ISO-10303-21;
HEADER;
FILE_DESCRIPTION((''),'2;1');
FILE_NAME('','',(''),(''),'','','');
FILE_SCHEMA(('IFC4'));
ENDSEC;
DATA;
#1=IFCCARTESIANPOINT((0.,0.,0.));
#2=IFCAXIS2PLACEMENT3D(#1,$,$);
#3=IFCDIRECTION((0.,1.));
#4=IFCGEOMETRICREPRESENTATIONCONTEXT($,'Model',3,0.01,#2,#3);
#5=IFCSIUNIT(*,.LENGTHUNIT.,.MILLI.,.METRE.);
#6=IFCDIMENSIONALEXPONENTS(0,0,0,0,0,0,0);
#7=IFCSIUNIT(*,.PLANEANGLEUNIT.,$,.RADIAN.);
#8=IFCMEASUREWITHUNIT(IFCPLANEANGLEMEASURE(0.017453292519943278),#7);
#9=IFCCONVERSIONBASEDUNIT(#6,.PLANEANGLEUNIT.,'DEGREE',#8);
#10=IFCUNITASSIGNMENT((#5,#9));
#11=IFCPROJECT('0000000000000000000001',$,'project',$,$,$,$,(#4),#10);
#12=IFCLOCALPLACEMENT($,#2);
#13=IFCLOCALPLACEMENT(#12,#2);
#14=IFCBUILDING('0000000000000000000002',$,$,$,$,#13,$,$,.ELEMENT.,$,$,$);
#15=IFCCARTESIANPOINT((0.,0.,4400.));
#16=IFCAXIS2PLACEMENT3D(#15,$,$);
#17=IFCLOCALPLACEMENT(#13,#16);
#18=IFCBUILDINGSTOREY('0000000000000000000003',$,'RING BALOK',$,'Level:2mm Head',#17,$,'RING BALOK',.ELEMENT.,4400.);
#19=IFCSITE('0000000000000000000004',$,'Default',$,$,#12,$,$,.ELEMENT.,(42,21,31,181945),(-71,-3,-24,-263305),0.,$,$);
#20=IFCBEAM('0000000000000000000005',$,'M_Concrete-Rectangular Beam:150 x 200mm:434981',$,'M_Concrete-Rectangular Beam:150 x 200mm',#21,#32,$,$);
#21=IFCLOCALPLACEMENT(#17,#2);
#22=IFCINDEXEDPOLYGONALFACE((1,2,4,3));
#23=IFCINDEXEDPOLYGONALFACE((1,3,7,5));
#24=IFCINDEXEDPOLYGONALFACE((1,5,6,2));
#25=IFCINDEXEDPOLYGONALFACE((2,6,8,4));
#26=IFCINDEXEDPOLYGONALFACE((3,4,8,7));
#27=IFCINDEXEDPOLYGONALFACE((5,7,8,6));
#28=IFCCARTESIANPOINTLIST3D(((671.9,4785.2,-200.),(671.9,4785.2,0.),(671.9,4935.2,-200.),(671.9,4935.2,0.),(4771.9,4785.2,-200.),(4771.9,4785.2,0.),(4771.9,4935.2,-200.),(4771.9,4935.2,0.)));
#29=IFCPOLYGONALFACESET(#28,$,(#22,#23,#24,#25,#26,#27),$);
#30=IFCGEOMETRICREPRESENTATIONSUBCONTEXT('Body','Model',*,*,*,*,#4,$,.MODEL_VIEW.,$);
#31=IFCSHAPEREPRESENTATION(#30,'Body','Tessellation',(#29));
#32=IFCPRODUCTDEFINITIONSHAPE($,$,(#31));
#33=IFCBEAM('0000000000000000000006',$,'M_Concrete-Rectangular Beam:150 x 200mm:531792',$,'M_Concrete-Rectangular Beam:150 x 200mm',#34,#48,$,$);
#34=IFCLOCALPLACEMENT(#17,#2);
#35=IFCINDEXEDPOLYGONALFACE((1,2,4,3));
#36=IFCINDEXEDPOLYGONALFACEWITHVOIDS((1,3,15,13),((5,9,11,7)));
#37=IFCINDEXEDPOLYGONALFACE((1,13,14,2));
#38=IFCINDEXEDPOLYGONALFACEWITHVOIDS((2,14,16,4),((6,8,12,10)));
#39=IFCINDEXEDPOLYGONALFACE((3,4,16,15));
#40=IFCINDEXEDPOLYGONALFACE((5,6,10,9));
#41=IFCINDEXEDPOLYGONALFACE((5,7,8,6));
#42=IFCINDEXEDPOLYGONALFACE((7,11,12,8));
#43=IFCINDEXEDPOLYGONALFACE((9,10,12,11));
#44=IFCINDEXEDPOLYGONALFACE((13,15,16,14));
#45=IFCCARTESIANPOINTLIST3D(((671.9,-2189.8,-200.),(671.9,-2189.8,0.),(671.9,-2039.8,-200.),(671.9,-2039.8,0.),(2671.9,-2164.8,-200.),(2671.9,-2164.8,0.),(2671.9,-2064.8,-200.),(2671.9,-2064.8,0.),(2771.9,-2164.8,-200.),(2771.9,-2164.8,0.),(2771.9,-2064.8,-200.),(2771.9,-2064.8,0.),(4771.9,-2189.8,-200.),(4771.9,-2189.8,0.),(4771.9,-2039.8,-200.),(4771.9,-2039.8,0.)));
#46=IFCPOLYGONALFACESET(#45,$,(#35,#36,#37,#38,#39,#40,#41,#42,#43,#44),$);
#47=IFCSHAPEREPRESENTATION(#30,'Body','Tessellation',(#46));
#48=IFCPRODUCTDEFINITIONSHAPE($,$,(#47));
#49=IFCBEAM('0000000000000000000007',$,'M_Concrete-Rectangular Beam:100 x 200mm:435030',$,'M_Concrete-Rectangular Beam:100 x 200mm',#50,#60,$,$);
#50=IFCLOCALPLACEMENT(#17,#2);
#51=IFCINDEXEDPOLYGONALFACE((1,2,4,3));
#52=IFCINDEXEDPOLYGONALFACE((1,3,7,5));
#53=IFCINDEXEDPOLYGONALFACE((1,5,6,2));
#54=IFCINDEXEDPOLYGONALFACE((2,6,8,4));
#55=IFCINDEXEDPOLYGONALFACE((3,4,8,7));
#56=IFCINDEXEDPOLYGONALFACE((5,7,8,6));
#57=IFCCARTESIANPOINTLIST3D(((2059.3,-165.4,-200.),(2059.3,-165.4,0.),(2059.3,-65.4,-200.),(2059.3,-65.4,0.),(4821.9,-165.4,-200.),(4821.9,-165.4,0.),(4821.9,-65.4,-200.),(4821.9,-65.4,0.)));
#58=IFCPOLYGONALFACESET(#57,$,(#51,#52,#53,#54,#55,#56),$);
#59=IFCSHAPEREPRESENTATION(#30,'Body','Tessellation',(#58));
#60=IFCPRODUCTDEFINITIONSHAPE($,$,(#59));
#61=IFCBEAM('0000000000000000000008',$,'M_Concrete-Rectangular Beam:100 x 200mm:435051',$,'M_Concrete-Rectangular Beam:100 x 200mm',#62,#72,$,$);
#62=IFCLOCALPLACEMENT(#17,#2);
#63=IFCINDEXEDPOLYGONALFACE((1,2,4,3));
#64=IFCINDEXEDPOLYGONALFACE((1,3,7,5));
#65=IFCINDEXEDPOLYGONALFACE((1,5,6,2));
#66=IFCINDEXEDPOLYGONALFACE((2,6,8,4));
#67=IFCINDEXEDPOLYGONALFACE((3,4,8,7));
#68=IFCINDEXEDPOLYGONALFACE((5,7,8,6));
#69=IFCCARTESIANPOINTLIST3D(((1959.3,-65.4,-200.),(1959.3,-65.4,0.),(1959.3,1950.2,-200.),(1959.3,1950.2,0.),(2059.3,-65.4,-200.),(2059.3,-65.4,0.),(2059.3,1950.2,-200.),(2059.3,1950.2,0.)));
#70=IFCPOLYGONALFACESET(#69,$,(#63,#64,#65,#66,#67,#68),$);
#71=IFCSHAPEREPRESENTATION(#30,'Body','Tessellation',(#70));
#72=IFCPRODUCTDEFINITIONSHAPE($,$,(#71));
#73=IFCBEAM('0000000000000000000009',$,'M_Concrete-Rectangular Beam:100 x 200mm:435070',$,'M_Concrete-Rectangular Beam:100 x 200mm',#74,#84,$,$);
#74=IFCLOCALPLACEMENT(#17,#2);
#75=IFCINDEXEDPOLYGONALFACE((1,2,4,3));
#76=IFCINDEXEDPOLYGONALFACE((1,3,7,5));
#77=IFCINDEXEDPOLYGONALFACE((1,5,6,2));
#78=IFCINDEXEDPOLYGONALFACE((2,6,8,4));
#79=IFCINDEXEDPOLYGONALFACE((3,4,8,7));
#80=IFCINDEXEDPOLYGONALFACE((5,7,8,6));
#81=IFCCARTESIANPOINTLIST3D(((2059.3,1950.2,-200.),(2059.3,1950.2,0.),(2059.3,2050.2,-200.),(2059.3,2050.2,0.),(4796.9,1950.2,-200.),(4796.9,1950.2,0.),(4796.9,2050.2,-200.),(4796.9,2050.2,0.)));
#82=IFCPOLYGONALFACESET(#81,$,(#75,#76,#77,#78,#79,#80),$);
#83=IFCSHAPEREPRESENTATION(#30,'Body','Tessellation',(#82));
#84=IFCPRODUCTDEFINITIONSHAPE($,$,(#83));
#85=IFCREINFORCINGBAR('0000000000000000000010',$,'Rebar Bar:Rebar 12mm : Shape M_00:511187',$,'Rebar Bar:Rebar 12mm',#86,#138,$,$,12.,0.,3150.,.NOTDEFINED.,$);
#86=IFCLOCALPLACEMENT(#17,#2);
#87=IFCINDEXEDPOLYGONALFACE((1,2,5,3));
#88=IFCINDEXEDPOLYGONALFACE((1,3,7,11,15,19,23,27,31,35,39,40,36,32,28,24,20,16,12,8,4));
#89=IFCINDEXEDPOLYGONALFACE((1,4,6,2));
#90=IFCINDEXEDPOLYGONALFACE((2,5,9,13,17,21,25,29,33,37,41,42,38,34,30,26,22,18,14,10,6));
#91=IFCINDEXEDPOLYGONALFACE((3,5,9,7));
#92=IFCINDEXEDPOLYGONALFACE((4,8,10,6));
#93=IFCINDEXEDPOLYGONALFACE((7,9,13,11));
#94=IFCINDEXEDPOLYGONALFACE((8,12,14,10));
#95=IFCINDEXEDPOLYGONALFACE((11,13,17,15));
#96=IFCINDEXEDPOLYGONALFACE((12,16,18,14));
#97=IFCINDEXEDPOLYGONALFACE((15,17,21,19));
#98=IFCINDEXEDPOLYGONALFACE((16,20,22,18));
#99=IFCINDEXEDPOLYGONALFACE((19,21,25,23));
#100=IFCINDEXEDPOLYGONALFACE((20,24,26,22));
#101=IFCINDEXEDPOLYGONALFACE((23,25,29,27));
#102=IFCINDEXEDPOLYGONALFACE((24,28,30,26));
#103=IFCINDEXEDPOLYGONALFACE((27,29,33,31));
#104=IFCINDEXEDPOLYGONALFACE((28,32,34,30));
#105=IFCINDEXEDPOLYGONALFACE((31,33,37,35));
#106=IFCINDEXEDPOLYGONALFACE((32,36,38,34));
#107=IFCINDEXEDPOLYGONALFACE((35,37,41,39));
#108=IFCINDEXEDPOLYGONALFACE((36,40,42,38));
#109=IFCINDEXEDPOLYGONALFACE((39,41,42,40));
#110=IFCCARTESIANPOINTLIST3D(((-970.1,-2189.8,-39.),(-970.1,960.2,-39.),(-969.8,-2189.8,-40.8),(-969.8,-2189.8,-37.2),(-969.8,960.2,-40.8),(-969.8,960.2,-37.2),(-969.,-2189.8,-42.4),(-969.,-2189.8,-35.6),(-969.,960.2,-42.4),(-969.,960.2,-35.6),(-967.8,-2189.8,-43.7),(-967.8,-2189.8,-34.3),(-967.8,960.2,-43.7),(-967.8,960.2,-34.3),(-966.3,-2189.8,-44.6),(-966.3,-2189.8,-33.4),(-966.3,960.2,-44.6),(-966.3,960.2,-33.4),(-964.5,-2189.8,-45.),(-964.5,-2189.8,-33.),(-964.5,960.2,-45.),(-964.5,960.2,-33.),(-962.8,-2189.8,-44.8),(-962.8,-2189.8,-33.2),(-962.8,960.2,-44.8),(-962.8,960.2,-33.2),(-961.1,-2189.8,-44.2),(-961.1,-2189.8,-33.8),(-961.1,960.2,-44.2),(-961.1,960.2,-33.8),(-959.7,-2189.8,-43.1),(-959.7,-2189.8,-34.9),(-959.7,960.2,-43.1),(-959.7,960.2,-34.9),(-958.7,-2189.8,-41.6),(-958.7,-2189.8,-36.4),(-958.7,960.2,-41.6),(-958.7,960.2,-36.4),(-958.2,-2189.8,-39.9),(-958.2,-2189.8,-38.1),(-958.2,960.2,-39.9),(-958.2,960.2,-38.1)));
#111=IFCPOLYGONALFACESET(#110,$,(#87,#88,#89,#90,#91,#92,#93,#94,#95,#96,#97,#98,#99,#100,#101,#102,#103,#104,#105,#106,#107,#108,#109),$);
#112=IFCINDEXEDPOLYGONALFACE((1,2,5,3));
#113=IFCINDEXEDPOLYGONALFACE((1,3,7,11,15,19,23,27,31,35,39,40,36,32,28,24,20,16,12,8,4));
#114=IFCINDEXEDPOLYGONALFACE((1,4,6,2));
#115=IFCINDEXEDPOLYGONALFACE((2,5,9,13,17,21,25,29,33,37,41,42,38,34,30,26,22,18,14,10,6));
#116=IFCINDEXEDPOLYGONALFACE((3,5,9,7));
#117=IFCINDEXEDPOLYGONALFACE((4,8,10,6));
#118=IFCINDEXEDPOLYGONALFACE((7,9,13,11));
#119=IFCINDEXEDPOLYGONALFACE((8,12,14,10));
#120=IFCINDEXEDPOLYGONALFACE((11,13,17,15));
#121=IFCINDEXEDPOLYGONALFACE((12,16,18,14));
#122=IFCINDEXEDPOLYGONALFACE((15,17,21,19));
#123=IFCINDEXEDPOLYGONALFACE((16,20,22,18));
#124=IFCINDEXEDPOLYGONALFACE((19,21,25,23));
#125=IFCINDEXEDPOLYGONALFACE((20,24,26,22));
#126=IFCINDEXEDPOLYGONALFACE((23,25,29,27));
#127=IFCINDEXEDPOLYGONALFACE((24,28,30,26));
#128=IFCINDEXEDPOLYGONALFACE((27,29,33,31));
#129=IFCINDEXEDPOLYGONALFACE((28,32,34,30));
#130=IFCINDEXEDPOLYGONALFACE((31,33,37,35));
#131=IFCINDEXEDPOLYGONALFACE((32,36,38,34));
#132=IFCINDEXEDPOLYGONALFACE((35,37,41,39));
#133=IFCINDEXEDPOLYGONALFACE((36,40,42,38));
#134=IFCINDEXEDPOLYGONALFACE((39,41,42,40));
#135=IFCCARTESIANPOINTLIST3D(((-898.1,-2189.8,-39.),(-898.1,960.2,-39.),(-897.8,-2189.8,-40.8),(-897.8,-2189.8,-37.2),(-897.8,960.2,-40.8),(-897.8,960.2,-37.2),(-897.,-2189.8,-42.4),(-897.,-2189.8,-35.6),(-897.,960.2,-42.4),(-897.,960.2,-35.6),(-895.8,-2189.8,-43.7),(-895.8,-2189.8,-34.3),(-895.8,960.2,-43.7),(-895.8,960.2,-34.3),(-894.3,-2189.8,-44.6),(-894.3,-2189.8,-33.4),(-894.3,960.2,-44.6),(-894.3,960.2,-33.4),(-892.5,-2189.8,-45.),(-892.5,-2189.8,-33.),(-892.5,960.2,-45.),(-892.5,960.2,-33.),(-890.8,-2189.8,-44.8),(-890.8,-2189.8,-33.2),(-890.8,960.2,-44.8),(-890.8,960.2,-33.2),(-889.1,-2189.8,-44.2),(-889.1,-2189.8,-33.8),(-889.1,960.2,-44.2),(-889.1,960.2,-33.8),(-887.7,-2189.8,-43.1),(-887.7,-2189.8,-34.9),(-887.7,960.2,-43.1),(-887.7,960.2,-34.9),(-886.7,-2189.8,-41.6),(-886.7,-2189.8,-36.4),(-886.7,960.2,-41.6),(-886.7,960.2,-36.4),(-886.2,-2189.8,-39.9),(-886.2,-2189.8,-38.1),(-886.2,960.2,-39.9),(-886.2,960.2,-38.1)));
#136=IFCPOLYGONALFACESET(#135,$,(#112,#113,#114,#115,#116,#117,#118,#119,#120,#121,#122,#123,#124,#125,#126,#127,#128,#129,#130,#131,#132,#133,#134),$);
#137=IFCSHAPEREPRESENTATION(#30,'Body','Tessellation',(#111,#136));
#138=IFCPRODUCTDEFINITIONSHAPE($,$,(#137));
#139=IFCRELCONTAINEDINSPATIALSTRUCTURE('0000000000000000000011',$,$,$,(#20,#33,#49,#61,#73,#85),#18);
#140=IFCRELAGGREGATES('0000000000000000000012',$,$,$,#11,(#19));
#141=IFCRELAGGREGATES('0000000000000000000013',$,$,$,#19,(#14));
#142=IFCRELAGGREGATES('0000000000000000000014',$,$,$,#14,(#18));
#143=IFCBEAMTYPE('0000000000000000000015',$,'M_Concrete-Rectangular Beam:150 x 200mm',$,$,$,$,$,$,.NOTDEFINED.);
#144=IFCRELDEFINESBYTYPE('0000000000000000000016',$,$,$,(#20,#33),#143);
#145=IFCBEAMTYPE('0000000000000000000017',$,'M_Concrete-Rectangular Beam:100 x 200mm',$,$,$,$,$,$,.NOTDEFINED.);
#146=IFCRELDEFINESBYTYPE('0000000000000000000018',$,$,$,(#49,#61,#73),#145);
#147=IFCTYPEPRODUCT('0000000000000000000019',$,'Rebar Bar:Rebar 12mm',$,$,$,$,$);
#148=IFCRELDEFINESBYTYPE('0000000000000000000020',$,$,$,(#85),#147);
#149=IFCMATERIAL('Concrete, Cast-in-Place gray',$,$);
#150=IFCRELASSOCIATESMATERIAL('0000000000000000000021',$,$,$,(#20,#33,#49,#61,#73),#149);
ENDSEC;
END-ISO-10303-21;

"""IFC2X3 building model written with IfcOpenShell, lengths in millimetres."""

from ifc_helpers import new_model, entity, si_unit, converted_unit, direction, frame, frame_2d, origin, origin_2d_with_axis, place, context, subcontext, project, spatial, rectangle, extrude, boolean, material, type_object, element, save


model = new_model("IFC2X3")

# Units and contexts
model_context = context("Model", 3, precision=0.01, world=origin(), true_north=direction((0.0, 1.0)))
body_context = subcontext(model_context, "Body", "Model", "MODEL_VIEW")
ifc_project = project(units=[si_unit("LENGTHUNIT", "METRE", prefix="MILLI"), converted_unit("PLANEANGLEUNIT", "DEGREE", entity("IfcPlaneAngleMeasure", 0.017453292519943278), si_unit("PLANEANGLEUNIT", "RADIAN"), dimensions=[0, 0, 0, 0, 0, 0, 0])], contexts=[model_context])

# Site, building, storey
site_placement = place(None, origin())
site = spatial("IfcSite", under=ifc_project, at=site_placement, Name="Default", CompositionType="ELEMENT", RefLatitude=(42, 21, 31, 181945), RefLongitude=(-71, -3, -24, -263305), RefElevation=0.0)
building_placement = place(site_placement, origin())
building = spatial("IfcBuilding", under=site, at=building_placement, CompositionType="ELEMENT")
storey_placement = place(building_placement, frame((0.0, 0.0, 4400.0)))
storey = spatial("IfcBuildingStorey", under=building, at=storey_placement, Name="RING BALOK", ObjectType="Level:2mm Head", LongName="RING BALOK", CompositionType="ELEMENT", Elevation=4400.0)

# Shared definitions
ifc_material = material(Name="Concrete, Cast-in-Place gray")

# Beams
beam_type_1 = type_object("IfcBeamType", Name="M_Concrete-Rectangular Beam:150 x 200mm", PredefinedType="NOTDEFINED")
beam_1_placement = place(storey_placement, frame((4871.9, 4860.2, 0.0), z_axis=(0.0, 0.0, 1.0), x_axis=(-1.0, 0.0, 0.0)))
element("IfcBeam", 1, at=beam_1_placement, inside=storey, type_object=beam_type_1, material=ifc_material, Name="M_Concrete-Rectangular Beam:150 x 200mm:434981", ObjectType="M_Concrete-Rectangular Beam:150 x 200mm", context=body_context, shape_type="SweptSolid", body=[
    extrude(rectangle(XDim=200.0, YDim=150.0, at=frame_2d((0.0, 0.0), x_axis=(1.0, 0.0))), frame((100.0, 0.0, -100.0), z_axis=(1.0, 0.0, 0.0), x_axis=(0.0, 0.0, -1.0)), (0.0, 0.0, 1.0), 4100.0),
])
beam_2_placement = place(storey_placement, frame((4871.9, -2114.8, 0.0), z_axis=(0.0, 0.0, 1.0), x_axis=(-1.0, 0.0, 0.0)))
element("IfcBeam", 2, at=beam_2_placement, inside=storey, type_object=beam_type_1, material=ifc_material, Name="M_Concrete-Rectangular Beam:150 x 200mm:531792", ObjectType="M_Concrete-Rectangular Beam:150 x 200mm", context=body_context, shape_type="CSG", body=[
    boolean("DIFFERENCE", extrude(rectangle(XDim=200.0, YDim=150.0, at=frame_2d((0.0, 0.0), x_axis=(1.0, 0.0))), frame((100.0, 0.0, -100.0), z_axis=(1.0, 0.0, 0.0), x_axis=(0.0, 0.0, -1.0)), (0.0, 0.0, 1.0), 4100.0), extrude(rectangle(XDim=100.0, YDim=100.0, at=origin_2d_with_axis()), frame((2150.0, 0.0, 0.0), z_axis=(0.0, 0.0, -1.0), x_axis=(0.0, 1.0, 0.0)), (0.0, 0.0, 1.0), 200.0)),
])
beam_type_2 = type_object("IfcBeamType", Name="M_Concrete-Rectangular Beam:100 x 200mm", PredefinedType="NOTDEFINED")
beam_3_placement = place(storey_placement, frame((4871.9, -115.4, 0.0), z_axis=(0.0, 0.0, 1.0), x_axis=(-1.0, 0.0, 0.0)))
element("IfcBeam", 3, at=beam_3_placement, inside=storey, type_object=beam_type_2, material=ifc_material, Name="M_Concrete-Rectangular Beam:100 x 200mm:435030", ObjectType="M_Concrete-Rectangular Beam:100 x 200mm", context=body_context, shape_type="SweptSolid", body=[
    extrude(rectangle(XDim=200.0, YDim=100.0, at=origin_2d_with_axis()), frame((50.0, 0.0, -100.0), z_axis=(1.0, 0.0, 0.0), x_axis=(0.0, 0.0, -1.0)), (0.0, 0.0, 1.0), 2762.6),
])
beam_4_placement = place(storey_placement, frame((2009.3, -115.4, 0.0), z_axis=(0.0, 0.0, 1.0), x_axis=(0.0, 1.0, 0.0)))
element("IfcBeam", 4, at=beam_4_placement, inside=storey, type_object=beam_type_2, material=ifc_material, Name="M_Concrete-Rectangular Beam:100 x 200mm:435051", ObjectType="M_Concrete-Rectangular Beam:100 x 200mm", context=body_context, shape_type="SweptSolid", body=[
    extrude(rectangle(XDim=200.0, YDim=100.0, at=frame_2d((0.0, 0.0), x_axis=(1.0, 0.0))), frame((50.0, 0.0, -100.0), z_axis=(1.0, 0.0, 0.0), x_axis=(0.0, 0.0, -1.0)), (0.0, 0.0, 1.0), 2015.5),
])
beam_5_placement = place(storey_placement, frame((2009.3, 2000.2, 0.0)))
element("IfcBeam", 5, at=beam_5_placement, inside=storey, type_object=beam_type_2, material=ifc_material, Name="M_Concrete-Rectangular Beam:100 x 200mm:435070", ObjectType="M_Concrete-Rectangular Beam:100 x 200mm", context=body_context, shape_type="SweptSolid", body=[
    extrude(rectangle(XDim=200.0, YDim=100.0, at=frame_2d((0.0, 0.0), x_axis=(1.0, 0.0))), frame((50.0, 0.0, -100.0), z_axis=(1.0, 0.0, 0.0), x_axis=(0.0, 0.0, -1.0)), (0.0, 0.0, 1.0), 2737.6),
])

# Reinforcing bar
type_product_1 = type_object("IfcTypeProduct", Name="Rebar Bar:Rebar 12mm")
reinforcing_bar_1_placement = place(storey_placement, origin())
element("IfcReinforcingBar", 6, at=reinforcing_bar_1_placement, inside=storey, type_object=type_product_1, Name="Rebar Bar:Rebar 12mm : Shape M_00:511187", ObjectType="Rebar Bar:Rebar 12mm", BarLength=3150.0, BarRole="NOTDEFINED", CrossSectionArea=0.0, NominalDiameter=12.0, context=body_context, shape_type="AdvancedSweptSolid", body=[
    entity("IfcSweptDiskSolid", entity("IfcCompositeCurve", [entity("IfcCompositeCurveSegment", "CONTINUOUS", True, entity("IfcPolyline", [entity("IfcCartesianPoint", [-964.1, 960.2, -39.0]), entity("IfcCartesianPoint", [-964.1, -2189.8, -39.0])]))], False), 6.0, None, 0.0, 1.0),
    entity("IfcSweptDiskSolid", entity("IfcCompositeCurve", [entity("IfcCompositeCurveSegment", "CONTINUOUS", True, entity("IfcPolyline", [entity("IfcCartesianPoint", [-892.1, 960.2, -39.0]), entity("IfcCartesianPoint", [-892.1, -2189.8, -39.0])]))], False), 6.0, None, 0.0, 1.0),
])

save(model, "model.ifc")
